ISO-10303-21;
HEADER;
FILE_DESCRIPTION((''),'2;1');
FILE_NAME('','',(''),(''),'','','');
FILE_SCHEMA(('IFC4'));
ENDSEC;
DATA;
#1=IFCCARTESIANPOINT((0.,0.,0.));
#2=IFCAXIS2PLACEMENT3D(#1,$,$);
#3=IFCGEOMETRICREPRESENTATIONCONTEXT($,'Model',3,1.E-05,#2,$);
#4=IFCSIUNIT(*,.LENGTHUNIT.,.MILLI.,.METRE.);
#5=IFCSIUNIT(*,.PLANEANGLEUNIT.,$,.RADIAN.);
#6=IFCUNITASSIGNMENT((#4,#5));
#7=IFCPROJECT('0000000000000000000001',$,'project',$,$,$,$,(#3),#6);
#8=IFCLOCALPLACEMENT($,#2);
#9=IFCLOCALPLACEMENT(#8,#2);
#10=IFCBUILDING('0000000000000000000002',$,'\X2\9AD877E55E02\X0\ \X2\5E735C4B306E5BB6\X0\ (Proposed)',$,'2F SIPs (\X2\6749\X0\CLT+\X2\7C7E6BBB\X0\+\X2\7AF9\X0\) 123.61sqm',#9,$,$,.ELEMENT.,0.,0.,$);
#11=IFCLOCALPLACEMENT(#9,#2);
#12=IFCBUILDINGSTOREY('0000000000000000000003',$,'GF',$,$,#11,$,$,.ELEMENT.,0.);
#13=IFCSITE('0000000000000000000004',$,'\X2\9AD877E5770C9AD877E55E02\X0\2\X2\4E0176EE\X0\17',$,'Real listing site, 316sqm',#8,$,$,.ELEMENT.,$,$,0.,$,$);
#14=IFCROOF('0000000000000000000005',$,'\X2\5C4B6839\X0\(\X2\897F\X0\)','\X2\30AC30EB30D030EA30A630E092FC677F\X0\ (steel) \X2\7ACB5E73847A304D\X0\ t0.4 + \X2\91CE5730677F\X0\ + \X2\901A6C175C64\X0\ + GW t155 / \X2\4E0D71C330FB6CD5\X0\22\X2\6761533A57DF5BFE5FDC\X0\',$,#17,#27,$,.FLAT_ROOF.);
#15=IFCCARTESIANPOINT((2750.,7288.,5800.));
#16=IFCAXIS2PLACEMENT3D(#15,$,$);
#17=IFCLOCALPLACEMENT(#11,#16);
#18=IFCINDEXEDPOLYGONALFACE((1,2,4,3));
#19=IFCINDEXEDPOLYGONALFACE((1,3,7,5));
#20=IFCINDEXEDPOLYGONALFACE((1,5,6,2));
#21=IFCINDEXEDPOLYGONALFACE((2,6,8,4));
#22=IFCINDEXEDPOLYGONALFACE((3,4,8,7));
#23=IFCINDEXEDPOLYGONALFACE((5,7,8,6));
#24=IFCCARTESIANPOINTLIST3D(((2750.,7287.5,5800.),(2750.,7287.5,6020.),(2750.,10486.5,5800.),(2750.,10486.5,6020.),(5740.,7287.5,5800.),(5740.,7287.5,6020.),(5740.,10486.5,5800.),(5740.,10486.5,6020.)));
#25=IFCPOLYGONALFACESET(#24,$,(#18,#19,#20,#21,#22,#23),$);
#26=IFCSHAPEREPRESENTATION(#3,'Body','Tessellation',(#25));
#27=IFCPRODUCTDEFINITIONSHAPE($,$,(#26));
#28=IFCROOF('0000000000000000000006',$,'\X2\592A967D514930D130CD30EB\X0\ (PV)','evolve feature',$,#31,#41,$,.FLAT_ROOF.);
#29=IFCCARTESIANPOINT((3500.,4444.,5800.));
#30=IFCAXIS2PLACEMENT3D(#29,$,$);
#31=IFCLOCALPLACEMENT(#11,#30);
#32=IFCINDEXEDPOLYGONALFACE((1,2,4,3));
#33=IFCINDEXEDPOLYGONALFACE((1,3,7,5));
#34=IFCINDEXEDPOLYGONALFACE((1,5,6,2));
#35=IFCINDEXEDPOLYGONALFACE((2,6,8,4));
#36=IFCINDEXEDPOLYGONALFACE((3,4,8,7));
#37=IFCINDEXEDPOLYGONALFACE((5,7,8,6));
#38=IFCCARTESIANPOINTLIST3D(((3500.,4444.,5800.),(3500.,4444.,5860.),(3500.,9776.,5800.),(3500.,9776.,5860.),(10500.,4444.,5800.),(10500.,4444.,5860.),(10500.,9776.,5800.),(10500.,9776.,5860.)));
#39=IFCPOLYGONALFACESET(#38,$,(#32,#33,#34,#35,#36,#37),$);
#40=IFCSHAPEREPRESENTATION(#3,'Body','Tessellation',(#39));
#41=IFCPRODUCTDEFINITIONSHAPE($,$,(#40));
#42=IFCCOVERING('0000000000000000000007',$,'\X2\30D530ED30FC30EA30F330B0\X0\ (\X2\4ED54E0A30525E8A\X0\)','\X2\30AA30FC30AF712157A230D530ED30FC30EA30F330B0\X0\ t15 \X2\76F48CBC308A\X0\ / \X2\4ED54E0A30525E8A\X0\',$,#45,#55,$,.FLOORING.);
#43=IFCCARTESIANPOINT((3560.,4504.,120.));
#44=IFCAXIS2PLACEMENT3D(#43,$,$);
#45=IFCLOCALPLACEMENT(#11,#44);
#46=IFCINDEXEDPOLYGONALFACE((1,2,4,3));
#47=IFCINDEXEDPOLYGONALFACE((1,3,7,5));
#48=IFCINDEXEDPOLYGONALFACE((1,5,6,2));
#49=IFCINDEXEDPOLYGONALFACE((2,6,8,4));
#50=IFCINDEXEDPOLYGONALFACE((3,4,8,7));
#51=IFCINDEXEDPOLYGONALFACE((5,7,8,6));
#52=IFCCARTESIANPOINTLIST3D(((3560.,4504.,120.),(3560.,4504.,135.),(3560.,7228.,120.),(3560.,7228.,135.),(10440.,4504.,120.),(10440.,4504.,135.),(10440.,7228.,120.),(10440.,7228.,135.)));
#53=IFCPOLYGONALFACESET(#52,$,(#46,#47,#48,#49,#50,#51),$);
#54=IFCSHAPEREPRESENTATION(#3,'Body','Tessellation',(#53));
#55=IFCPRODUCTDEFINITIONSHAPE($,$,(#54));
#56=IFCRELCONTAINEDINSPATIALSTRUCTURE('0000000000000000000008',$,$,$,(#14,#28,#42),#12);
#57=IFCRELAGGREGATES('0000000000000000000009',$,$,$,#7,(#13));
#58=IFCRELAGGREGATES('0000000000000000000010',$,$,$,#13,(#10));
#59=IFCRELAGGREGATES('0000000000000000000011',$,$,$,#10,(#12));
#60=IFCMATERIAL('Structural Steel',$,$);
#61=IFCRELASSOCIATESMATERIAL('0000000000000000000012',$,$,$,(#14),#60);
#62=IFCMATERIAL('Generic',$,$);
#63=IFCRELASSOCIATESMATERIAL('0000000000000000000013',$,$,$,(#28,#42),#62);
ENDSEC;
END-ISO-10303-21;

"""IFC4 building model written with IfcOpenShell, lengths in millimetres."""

from ifc_helpers import new_model, si_unit, frame, frame_2d, origin, place, context, project, spatial, rectangle, extrude, material, element, save


model = new_model("IFC4")

# Units and contexts
model_context = context("Model", 3, precision=1e-05, world=origin())
ifc_project = project(units=[si_unit("LENGTHUNIT", "METRE", prefix="MILLI"), si_unit("PLANEANGLEUNIT", "RADIAN")], contexts=[model_context])

# Site, building, storey
site_placement = place(None, origin())
site = spatial("IfcSite", under=ifc_project, at=site_placement, Name="高知県高知市2丁目17", ObjectType="Real listing site, 316sqm", CompositionType="ELEMENT", RefElevation=0.0)
building_placement = place(site_placement, origin())
building = spatial("IfcBuilding", under=site, at=building_placement, Name="高知市 平屋の家 (Proposed)", ObjectType="2F SIPs (杉CLT+籾殻+竹) 123.61sqm", CompositionType="ELEMENT", ElevationOfRefHeight=0.0, ElevationOfTerrain=0.0)
storey_placement = place(building_placement, origin())
storey = spatial("IfcBuildingStorey", under=building, at=storey_placement, Name="GF", CompositionType="ELEMENT", Elevation=0.0)

# Shared definitions
ifc_material_1 = material(Name="Generic")

# Roofs
ifc_material_2 = material(Name="Structural Steel")
roof_1_placement = place(storey_placement, frame((2750.0, 7288.0, 5800.0)))
element("IfcRoof", 1, at=roof_1_placement, inside=storey, material=ifc_material_2, Name="屋根(西)", Description="ガルバリウム鋼板 (steel) 立平葺き t0.4 + 野地板 + 通気層 + GW t155 / 不燃・法22条区域対応", PredefinedType="FLAT_ROOF", context=model_context, shape_type="SweptSolid", body=[
    extrude(rectangle(XDim=2990.0, YDim=3199.0, at=frame_2d((1495.0, 1599.0))), frame((2750.0, 7288.0, 5800.0)), (0.0, 0.0, 1.0), 220.0),
])
roof_2_placement = place(storey_placement, frame((3500.0, 4444.0, 5800.0)))
element("IfcRoof", 2, at=roof_2_placement, inside=storey, material=ifc_material_1, Name="太陽光パネル (PV)", Description="evolve feature", PredefinedType="FLAT_ROOF", context=model_context, shape_type="SweptSolid", body=[
    extrude(rectangle(XDim=7000.0, YDim=5332.0, at=frame_2d((3500.0, 2666.0))), frame((3500.0, 4444.0, 5800.0)), (0.0, 0.0, 1.0), 60.0),
])

# Covering
covering_placement = place(storey_placement, frame((3560.0, 4504.0, 120.0)))
element("IfcCovering", 3, at=covering_placement, inside=storey, material=ifc_material_1, Name="フローリング (仕上げ床)", Description="オーク無垢フローリング t15 直貼り / 仕上げ床", PredefinedType="FLOORING", context=model_context, shape_type="SweptSolid", body=[
    extrude(rectangle(XDim=6880.0, YDim=2724.0, at=frame_2d((3440.0, 1362.0))), frame((3560.0, 4504.0, 120.0)), (0.0, 0.0, 1.0), 15.0),
])

save(model, "model.ifc")
